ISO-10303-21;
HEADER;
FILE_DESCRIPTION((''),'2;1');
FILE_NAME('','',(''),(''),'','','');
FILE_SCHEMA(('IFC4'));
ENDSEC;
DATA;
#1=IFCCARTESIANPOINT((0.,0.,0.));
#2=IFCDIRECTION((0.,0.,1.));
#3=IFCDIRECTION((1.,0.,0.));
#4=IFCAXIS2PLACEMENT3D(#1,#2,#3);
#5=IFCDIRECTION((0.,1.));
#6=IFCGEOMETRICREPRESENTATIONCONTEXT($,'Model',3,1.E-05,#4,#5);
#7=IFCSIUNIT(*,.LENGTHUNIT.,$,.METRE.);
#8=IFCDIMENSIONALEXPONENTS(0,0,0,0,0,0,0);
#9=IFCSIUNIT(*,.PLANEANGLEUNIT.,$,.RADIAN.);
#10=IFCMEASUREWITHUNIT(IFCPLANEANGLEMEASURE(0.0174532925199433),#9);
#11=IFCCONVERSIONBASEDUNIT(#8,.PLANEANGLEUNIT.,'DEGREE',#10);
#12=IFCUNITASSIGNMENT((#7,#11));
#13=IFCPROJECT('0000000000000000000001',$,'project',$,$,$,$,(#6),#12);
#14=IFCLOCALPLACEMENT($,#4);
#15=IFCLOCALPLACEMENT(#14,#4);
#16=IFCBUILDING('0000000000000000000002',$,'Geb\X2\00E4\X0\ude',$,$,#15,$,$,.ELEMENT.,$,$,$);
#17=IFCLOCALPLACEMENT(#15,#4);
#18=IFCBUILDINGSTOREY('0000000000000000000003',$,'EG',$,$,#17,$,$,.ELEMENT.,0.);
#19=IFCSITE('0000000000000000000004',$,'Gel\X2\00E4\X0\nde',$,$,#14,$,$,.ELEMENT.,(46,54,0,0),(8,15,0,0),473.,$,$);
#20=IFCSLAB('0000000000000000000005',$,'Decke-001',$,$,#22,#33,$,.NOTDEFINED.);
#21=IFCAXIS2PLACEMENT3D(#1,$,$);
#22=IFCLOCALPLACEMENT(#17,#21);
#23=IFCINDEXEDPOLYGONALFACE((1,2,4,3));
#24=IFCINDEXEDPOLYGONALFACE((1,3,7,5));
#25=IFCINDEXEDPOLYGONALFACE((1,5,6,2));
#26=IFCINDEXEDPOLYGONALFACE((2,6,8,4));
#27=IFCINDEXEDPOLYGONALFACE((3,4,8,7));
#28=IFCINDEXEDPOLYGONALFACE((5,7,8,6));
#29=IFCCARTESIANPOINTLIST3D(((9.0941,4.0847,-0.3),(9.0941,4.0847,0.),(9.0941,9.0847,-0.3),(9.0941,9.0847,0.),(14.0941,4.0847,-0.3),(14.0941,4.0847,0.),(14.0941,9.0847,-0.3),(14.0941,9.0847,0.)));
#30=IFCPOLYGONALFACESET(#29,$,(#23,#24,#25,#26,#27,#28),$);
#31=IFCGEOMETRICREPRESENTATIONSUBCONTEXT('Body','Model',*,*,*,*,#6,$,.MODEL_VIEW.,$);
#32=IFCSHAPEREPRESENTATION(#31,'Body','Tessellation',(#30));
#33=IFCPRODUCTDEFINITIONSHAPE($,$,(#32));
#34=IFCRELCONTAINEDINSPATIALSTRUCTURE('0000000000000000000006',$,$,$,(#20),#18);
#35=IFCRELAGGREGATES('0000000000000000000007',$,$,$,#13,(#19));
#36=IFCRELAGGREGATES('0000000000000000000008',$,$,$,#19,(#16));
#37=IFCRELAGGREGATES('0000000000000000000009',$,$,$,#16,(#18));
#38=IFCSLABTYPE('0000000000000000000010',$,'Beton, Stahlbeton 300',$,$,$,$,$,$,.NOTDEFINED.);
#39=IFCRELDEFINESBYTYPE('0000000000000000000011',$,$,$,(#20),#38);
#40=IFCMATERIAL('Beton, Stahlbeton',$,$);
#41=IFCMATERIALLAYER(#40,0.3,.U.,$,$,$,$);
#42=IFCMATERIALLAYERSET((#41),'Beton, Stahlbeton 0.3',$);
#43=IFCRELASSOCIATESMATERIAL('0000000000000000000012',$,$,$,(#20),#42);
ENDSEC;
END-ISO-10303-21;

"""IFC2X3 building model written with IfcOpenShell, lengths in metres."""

from ifc_helpers import new_model, entity, si_unit, converted_unit, direction, frame, origin_with_axes, place, context, subcontext, project, spatial, polyline, outline, extrude, material, layer, layer_set, layer_usage, type_object, element, save


model = new_model("IFC2X3")

# Units and contexts
model_context = context("Model", 3, precision=1e-05, world=origin_with_axes(), true_north=direction((0.0, 1.0)))
body_context = subcontext(model_context, "Body", "Model", "MODEL_VIEW")
ifc_project = project(units=[si_unit("LENGTHUNIT", "METRE"), converted_unit("PLANEANGLEUNIT", "DEGREE", entity("IfcPlaneAngleMeasure", 0.0174532925199433), si_unit("PLANEANGLEUNIT", "RADIAN"), dimensions=[0, 0, 0, 0, 0, 0, 0])], contexts=[model_context])

# Site, building, storey
site_placement = place(None, origin_with_axes())
site = spatial("IfcSite", under=ifc_project, at=site_placement, Name="Gelände", CompositionType="ELEMENT", RefLatitude=(46, 54, 0, 0), RefLongitude=(8, 15, 0, 0), RefElevation=473.0)
building_placement = place(site_placement, origin_with_axes())
building = spatial("IfcBuilding", under=site, at=building_placement, Name="Gebäude", CompositionType="ELEMENT")
storey_placement = place(building_placement, origin_with_axes())
storey = spatial("IfcBuildingStorey", under=building, at=storey_placement, Name="EG", CompositionType="ELEMENT", Elevation=0.0)

# Slab
ifc_material = material(Name="Beton, Stahlbeton")
ifc_layer = layer(ifc_material, 0.3, ventilated="UNKNOWN")
ifc_layer_set = layer_set([ifc_layer], Name="Beton, Stahlbeton 0.3")
ifc_layer_usage = layer_usage(ifc_layer_set, "AXIS3", "NEGATIVE", 0.3)
slab_type = type_object("IfcSlabType", Name="Beton, Stahlbeton 300", PredefinedType="NOTDEFINED")
slab_placement = place(storey_placement, frame((9.0941, 4.0847, 0.0), z_axis=(0.0, 0.0, 1.0), x_axis=(1.0, 0.0, 0.0)))
element("IfcSlab", 1, at=slab_placement, inside=storey, type_object=slab_type, material=ifc_layer_usage, Name="Decke-001", PredefinedType="NOTDEFINED", context=body_context, shape_type="SweptSolid", body=[
    extrude(outline(polyline([(0.0, 0.0), (5.0, 0.0), (5.0, 5.0), (0.0, 5.0), (0.0, 0.0)])), frame((0.0, 0.0, -0.3), z_axis=(0.0, 0.0, 1.0), x_axis=(1.0, 0.0, 0.0)), (0.0, 0.0, 1.0), 0.3),
])

save(model, "model.ifc")
